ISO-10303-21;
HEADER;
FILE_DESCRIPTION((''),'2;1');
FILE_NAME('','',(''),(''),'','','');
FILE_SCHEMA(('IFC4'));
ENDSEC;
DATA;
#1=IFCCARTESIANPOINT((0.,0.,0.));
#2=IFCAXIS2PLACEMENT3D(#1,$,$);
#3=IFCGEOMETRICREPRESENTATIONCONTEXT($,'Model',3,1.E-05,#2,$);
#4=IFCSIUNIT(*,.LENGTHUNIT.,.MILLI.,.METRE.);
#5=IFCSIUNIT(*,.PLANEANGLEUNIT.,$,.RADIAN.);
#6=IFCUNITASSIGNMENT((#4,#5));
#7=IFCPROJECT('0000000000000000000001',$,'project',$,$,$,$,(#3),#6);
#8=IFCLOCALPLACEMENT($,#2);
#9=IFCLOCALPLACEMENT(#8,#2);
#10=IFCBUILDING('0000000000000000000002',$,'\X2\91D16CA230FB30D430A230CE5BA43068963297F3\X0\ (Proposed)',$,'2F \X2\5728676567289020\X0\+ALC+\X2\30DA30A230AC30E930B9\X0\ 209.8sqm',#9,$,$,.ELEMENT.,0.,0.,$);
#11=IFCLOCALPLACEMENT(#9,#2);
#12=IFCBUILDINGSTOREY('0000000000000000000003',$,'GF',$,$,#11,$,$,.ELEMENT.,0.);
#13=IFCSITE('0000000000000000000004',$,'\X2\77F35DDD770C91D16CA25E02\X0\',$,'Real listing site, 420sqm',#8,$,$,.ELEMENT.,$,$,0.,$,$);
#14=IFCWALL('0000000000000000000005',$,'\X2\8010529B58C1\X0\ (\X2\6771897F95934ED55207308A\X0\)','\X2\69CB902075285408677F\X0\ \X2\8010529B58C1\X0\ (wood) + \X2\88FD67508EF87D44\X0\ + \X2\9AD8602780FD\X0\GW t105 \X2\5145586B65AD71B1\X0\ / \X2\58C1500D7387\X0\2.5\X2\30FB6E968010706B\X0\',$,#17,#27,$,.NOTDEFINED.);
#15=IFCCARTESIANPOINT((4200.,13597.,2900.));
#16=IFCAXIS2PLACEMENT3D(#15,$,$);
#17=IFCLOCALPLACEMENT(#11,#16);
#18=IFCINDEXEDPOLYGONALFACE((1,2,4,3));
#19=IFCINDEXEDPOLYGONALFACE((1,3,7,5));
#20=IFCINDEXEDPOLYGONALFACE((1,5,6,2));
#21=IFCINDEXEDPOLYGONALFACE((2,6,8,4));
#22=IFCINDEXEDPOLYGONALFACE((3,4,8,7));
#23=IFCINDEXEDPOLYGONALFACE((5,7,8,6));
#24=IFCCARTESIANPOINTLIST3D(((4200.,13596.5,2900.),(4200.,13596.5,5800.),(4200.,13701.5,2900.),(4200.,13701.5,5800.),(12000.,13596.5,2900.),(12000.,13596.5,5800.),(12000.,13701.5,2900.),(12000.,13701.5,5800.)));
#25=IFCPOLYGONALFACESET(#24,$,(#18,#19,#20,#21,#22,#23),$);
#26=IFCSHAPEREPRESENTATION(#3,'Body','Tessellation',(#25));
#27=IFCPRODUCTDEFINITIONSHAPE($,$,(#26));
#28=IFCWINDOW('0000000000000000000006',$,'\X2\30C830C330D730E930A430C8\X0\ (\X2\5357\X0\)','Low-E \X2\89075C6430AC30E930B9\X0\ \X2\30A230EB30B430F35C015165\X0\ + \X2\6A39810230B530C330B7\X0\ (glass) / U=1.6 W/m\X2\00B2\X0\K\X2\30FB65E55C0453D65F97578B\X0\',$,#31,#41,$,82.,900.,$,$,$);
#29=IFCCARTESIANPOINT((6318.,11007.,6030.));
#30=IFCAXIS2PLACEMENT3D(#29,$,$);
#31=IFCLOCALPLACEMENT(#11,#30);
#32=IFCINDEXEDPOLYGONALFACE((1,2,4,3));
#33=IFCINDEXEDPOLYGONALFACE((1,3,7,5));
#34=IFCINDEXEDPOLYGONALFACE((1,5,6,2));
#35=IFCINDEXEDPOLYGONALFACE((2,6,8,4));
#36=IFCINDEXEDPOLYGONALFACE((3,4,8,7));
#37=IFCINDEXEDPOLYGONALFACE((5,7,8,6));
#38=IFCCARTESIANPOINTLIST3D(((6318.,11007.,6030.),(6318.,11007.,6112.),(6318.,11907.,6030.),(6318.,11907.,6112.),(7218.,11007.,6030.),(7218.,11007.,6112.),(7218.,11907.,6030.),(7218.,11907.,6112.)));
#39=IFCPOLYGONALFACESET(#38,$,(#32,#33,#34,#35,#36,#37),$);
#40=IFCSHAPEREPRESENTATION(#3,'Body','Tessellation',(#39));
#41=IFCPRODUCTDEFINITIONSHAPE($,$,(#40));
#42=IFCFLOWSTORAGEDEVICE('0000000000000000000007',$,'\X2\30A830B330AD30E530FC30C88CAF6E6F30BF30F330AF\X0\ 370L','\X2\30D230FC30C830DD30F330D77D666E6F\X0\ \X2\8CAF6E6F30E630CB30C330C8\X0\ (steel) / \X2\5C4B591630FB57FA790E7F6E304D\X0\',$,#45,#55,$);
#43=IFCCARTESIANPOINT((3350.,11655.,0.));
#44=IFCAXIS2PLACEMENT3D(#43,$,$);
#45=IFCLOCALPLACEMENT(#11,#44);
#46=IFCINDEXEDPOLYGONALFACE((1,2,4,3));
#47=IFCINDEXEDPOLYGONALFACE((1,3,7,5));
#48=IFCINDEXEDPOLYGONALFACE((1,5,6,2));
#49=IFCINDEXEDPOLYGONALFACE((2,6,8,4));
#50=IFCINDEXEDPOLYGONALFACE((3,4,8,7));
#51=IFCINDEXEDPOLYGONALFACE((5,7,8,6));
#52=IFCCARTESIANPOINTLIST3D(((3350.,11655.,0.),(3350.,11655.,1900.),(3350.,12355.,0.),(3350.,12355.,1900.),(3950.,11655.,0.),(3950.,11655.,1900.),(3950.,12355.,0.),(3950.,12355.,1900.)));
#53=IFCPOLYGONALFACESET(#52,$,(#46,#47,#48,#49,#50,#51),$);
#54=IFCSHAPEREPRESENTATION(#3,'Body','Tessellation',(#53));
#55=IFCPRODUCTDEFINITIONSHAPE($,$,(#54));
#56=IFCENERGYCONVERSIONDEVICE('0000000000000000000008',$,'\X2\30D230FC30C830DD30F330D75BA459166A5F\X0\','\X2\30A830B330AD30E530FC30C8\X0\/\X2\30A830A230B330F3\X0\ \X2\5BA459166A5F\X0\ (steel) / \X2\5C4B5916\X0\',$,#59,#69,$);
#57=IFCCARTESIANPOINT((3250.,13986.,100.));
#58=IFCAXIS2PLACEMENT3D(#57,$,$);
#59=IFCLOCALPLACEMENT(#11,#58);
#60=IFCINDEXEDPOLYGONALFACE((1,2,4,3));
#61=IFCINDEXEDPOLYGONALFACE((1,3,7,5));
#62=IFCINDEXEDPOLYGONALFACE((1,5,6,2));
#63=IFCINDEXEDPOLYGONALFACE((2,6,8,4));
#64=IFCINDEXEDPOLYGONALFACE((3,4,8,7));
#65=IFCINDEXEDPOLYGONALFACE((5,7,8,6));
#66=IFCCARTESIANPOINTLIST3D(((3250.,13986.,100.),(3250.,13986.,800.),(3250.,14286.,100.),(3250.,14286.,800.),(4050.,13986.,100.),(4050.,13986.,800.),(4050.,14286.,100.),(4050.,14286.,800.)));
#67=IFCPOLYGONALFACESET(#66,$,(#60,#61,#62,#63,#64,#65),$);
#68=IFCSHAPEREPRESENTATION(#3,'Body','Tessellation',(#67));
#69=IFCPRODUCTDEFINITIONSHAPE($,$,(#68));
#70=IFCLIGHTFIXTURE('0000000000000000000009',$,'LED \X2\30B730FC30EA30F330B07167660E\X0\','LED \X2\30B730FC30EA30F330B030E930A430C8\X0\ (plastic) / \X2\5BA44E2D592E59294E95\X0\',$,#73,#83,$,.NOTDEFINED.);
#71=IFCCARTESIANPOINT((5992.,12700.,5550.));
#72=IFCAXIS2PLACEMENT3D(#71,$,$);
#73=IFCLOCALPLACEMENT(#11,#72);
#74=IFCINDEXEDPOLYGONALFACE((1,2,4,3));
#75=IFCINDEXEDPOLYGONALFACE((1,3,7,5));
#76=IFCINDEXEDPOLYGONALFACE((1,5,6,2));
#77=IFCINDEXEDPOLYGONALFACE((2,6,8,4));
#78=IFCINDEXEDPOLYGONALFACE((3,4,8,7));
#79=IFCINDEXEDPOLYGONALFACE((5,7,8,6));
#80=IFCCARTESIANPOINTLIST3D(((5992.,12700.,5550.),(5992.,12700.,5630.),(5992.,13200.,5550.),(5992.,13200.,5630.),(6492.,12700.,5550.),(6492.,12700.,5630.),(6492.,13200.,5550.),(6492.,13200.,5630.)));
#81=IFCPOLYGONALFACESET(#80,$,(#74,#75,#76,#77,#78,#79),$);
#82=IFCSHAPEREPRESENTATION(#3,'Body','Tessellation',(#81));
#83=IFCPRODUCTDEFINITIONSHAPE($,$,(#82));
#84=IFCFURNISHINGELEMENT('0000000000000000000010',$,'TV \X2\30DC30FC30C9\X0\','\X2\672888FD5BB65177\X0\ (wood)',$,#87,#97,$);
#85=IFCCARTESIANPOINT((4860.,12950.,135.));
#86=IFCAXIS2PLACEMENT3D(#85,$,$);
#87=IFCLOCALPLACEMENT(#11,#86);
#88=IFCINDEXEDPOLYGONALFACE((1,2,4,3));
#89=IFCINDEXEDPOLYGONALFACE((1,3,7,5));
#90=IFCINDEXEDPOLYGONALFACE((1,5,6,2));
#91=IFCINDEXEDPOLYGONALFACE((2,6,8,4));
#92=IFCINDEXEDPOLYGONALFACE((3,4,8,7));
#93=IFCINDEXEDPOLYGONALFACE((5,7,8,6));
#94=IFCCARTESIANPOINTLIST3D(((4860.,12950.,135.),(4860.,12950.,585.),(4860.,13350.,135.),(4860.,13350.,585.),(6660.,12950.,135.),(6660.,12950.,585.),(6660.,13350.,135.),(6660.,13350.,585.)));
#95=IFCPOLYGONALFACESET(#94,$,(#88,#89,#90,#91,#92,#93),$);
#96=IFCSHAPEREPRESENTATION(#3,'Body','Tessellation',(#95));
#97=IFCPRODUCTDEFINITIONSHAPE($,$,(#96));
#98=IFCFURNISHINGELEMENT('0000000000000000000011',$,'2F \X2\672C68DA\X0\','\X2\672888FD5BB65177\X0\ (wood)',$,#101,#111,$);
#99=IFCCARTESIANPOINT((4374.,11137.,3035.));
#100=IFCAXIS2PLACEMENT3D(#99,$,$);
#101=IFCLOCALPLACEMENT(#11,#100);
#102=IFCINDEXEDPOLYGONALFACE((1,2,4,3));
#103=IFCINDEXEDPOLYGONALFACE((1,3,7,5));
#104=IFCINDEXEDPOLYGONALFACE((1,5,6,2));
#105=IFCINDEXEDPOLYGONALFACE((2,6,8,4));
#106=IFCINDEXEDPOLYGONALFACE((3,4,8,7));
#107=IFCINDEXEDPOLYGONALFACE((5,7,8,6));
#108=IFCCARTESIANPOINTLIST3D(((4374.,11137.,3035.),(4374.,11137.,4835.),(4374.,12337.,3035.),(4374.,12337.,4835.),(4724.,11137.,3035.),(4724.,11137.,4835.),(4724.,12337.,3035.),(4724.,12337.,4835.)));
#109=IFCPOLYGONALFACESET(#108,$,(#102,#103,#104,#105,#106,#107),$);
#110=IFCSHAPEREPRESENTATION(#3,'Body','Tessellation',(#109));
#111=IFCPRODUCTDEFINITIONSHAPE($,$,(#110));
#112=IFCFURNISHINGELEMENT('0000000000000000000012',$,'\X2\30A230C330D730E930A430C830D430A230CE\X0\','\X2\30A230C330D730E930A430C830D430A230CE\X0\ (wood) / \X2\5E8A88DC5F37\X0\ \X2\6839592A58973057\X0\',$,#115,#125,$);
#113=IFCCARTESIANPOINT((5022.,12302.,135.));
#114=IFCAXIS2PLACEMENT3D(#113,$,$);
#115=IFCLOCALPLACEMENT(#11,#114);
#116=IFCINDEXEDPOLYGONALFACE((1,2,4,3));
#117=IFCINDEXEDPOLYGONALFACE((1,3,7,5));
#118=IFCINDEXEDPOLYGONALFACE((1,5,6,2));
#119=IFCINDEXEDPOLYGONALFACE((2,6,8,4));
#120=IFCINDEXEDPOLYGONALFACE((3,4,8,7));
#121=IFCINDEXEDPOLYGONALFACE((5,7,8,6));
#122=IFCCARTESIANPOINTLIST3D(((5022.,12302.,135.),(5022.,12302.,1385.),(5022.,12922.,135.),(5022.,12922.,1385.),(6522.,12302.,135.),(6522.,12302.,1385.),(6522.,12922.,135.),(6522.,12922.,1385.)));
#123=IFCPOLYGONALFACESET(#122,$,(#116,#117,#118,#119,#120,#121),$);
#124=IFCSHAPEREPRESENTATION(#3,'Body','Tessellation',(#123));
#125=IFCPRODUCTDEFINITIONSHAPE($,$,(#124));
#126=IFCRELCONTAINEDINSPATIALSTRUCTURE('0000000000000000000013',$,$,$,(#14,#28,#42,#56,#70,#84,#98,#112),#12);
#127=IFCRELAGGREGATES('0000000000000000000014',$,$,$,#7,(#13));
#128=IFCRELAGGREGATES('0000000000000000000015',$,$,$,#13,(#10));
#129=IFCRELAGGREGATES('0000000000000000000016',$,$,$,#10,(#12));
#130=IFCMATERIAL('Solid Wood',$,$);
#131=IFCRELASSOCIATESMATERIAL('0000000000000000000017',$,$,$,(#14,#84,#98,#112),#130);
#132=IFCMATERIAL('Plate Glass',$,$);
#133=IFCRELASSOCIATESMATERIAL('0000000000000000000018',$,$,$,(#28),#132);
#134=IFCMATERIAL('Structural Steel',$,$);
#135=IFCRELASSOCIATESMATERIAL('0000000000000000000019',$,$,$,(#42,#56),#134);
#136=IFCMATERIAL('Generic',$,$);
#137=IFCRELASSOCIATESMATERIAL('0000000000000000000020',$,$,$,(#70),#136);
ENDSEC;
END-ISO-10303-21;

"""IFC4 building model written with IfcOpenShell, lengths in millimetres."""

from ifc_helpers import new_model, si_unit, frame, frame_2d, origin, place, context, project, spatial, rectangle, extrude, material, element, save


model = new_model("IFC4")

# Units and contexts
model_context = context("Model", 3, precision=1e-05, world=origin())
ifc_project = project(units=[si_unit("LENGTHUNIT", "METRE", prefix="MILLI"), si_unit("PLANEANGLEUNIT", "RADIAN")], contexts=[model_context])

# Site, building, storey
site_placement = place(None, origin())
site = spatial("IfcSite", under=ifc_project, at=site_placement, Name="石川県金沢市", ObjectType="Real listing site, 420sqm", CompositionType="ELEMENT", RefElevation=0.0)
building_placement = place(site_placement, origin())
building = spatial("IfcBuilding", under=site, at=building_placement, Name="金沢・ピアノ室と防音 (Proposed)", ObjectType="2F 在来木造+ALC+ペアガラス 209.8sqm", CompositionType="ELEMENT", ElevationOfRefHeight=0.0, ElevationOfTerrain=0.0)
storey_placement = place(building_placement, origin())
storey = spatial("IfcBuildingStorey", under=building, at=storey_placement, Name="GF", CompositionType="ELEMENT", Elevation=0.0)

# Shared definitions
ifc_material_1 = material(Name="Solid Wood")

# Wall
wall_1_placement = place(storey_placement, frame((4200.0, 13597.0, 2900.0)))
element("IfcWall", 1, at=wall_1_placement, inside=storey, material=ifc_material_1, Name="耐力壁 (東西間仕切り)", Description="構造用合板 耐力壁 (wood) + 製材軸組 + 高性能GW t105 充填断熱 / 壁倍率2.5・準耐火", PredefinedType="NOTDEFINED", context=model_context, shape_type="SweptSolid", body=[
    extrude(rectangle(XDim=7800.0, YDim=105.0, at=frame_2d((3900.0, 52.0))), frame((4200.0, 13597.0, 2900.0)), (0.0, 0.0, 1.0), 2900.0),
])

# Window
ifc_material_2 = material(Name="Plate Glass")
window_placement = place(storey_placement, frame((6318.0, 11007.0, 6030.0)))
element("IfcWindow", 2, at=window_placement, inside=storey, material=ifc_material_2, Name="トップライト (南)", Description="Low-E 複層ガラス アルゴン封入 + 樹脂サッシ (glass) / U=1.6 W/m²K・日射取得型", OverallHeight=82.0, OverallWidth=900.0, context=model_context, shape_type="SweptSolid", body=[
    extrude(rectangle(XDim=900.0, YDim=900.0, at=frame_2d((450.0, 450.0))), frame((6318.0, 11007.0, 6030.0)), (0.0, 0.0, 1.0), 82.0),
])

# Flow storage device
ifc_material_3 = material(Name="Structural Steel")
flow_storage_device_placement = place(storey_placement, frame((3350.0, 11655.0, 0.0)))
element("IfcFlowStorageDevice", 3, at=flow_storage_device_placement, inside=storey, material=ifc_material_3, Name="エコキュート貯湯タンク 370L", Description="ヒートポンプ給湯 貯湯ユニット (steel) / 屋外・基礎置き", context=model_context, shape_type="SweptSolid", body=[
    extrude(rectangle(XDim=600.0, YDim=700.0, at=frame_2d((300.0, 350.0))), frame((3350.0, 11655.0, 0.0)), (0.0, 0.0, 1.0), 1900.0),
])

# Energy conversion device
energy_conversion_device_placement = place(storey_placement, frame((3250.0, 13986.0, 100.0)))
element("IfcEnergyConversionDevice", 4, at=energy_conversion_device_placement, inside=storey, material=ifc_material_3, Name="ヒートポンプ室外機", Description="エコキュート/エアコン 室外機 (steel) / 屋外", context=model_context, shape_type="SweptSolid", body=[
    extrude(rectangle(XDim=800.0, YDim=300.0, at=frame_2d((400.0, 150.0))), frame((3250.0, 13986.0, 100.0)), (0.0, 0.0, 1.0), 700.0),
])

# Light fixture
ifc_material_4 = material(Name="Generic")
light_fixture_placement = place(storey_placement, frame((5992.0, 12700.0, 5550.0)))
element("IfcLightFixture", 5, at=light_fixture_placement, inside=storey, material=ifc_material_4, Name="LED シーリング照明", Description="LED シーリングライト (plastic) / 室中央天井", PredefinedType="NOTDEFINED", context=model_context, shape_type="SweptSolid", body=[
    extrude(rectangle(XDim=500.0, YDim=500.0, at=frame_2d((250.0, 250.0))), frame((5992.0, 12700.0, 5550.0)), (0.0, 0.0, 1.0), 80.0),
])

# Furnishing elements
furnishing_1_placement = place(storey_placement, frame((4860.0, 12950.0, 135.0)))
element("IfcFurnishingElement", 6, at=furnishing_1_placement, inside=storey, material=ifc_material_1, Name="TV ボード", Description="木製家具 (wood)", context=model_context, shape_type="SweptSolid", body=[
    extrude(rectangle(XDim=1800.0, YDim=400.0, at=frame_2d((900.0, 200.0))), frame((4860.0, 12950.0, 135.0)), (0.0, 0.0, 1.0), 450.0),
])
furnishing_2_placement = place(storey_placement, frame((4374.0, 11137.0, 3035.0)))
element("IfcFurnishingElement", 7, at=furnishing_2_placement, inside=storey, material=ifc_material_1, Name="2F 本棚", Description="木製家具 (wood)", context=model_context, shape_type="SweptSolid", body=[
    extrude(rectangle(XDim=350.0, YDim=1200.0, at=frame_2d((175.0, 600.0))), frame((4374.0, 11137.0, 3035.0)), (0.0, 0.0, 1.0), 1800.0),
])
furnishing_3_placement = place(storey_placement, frame((5022.0, 12302.0, 135.0)))
element("IfcFurnishingElement", 8, at=furnishing_3_placement, inside=storey, material=ifc_material_1, Name="アップライトピアノ", Description="アップライトピアノ (wood) / 床補強 根太増し", context=model_context, shape_type="SweptSolid", body=[
    extrude(rectangle(XDim=1500.0, YDim=620.0, at=frame_2d((750.0, 310.0))), frame((5022.0, 12302.0, 135.0)), (0.0, 0.0, 1.0), 1250.0),
])

save(model, "model.ifc")
